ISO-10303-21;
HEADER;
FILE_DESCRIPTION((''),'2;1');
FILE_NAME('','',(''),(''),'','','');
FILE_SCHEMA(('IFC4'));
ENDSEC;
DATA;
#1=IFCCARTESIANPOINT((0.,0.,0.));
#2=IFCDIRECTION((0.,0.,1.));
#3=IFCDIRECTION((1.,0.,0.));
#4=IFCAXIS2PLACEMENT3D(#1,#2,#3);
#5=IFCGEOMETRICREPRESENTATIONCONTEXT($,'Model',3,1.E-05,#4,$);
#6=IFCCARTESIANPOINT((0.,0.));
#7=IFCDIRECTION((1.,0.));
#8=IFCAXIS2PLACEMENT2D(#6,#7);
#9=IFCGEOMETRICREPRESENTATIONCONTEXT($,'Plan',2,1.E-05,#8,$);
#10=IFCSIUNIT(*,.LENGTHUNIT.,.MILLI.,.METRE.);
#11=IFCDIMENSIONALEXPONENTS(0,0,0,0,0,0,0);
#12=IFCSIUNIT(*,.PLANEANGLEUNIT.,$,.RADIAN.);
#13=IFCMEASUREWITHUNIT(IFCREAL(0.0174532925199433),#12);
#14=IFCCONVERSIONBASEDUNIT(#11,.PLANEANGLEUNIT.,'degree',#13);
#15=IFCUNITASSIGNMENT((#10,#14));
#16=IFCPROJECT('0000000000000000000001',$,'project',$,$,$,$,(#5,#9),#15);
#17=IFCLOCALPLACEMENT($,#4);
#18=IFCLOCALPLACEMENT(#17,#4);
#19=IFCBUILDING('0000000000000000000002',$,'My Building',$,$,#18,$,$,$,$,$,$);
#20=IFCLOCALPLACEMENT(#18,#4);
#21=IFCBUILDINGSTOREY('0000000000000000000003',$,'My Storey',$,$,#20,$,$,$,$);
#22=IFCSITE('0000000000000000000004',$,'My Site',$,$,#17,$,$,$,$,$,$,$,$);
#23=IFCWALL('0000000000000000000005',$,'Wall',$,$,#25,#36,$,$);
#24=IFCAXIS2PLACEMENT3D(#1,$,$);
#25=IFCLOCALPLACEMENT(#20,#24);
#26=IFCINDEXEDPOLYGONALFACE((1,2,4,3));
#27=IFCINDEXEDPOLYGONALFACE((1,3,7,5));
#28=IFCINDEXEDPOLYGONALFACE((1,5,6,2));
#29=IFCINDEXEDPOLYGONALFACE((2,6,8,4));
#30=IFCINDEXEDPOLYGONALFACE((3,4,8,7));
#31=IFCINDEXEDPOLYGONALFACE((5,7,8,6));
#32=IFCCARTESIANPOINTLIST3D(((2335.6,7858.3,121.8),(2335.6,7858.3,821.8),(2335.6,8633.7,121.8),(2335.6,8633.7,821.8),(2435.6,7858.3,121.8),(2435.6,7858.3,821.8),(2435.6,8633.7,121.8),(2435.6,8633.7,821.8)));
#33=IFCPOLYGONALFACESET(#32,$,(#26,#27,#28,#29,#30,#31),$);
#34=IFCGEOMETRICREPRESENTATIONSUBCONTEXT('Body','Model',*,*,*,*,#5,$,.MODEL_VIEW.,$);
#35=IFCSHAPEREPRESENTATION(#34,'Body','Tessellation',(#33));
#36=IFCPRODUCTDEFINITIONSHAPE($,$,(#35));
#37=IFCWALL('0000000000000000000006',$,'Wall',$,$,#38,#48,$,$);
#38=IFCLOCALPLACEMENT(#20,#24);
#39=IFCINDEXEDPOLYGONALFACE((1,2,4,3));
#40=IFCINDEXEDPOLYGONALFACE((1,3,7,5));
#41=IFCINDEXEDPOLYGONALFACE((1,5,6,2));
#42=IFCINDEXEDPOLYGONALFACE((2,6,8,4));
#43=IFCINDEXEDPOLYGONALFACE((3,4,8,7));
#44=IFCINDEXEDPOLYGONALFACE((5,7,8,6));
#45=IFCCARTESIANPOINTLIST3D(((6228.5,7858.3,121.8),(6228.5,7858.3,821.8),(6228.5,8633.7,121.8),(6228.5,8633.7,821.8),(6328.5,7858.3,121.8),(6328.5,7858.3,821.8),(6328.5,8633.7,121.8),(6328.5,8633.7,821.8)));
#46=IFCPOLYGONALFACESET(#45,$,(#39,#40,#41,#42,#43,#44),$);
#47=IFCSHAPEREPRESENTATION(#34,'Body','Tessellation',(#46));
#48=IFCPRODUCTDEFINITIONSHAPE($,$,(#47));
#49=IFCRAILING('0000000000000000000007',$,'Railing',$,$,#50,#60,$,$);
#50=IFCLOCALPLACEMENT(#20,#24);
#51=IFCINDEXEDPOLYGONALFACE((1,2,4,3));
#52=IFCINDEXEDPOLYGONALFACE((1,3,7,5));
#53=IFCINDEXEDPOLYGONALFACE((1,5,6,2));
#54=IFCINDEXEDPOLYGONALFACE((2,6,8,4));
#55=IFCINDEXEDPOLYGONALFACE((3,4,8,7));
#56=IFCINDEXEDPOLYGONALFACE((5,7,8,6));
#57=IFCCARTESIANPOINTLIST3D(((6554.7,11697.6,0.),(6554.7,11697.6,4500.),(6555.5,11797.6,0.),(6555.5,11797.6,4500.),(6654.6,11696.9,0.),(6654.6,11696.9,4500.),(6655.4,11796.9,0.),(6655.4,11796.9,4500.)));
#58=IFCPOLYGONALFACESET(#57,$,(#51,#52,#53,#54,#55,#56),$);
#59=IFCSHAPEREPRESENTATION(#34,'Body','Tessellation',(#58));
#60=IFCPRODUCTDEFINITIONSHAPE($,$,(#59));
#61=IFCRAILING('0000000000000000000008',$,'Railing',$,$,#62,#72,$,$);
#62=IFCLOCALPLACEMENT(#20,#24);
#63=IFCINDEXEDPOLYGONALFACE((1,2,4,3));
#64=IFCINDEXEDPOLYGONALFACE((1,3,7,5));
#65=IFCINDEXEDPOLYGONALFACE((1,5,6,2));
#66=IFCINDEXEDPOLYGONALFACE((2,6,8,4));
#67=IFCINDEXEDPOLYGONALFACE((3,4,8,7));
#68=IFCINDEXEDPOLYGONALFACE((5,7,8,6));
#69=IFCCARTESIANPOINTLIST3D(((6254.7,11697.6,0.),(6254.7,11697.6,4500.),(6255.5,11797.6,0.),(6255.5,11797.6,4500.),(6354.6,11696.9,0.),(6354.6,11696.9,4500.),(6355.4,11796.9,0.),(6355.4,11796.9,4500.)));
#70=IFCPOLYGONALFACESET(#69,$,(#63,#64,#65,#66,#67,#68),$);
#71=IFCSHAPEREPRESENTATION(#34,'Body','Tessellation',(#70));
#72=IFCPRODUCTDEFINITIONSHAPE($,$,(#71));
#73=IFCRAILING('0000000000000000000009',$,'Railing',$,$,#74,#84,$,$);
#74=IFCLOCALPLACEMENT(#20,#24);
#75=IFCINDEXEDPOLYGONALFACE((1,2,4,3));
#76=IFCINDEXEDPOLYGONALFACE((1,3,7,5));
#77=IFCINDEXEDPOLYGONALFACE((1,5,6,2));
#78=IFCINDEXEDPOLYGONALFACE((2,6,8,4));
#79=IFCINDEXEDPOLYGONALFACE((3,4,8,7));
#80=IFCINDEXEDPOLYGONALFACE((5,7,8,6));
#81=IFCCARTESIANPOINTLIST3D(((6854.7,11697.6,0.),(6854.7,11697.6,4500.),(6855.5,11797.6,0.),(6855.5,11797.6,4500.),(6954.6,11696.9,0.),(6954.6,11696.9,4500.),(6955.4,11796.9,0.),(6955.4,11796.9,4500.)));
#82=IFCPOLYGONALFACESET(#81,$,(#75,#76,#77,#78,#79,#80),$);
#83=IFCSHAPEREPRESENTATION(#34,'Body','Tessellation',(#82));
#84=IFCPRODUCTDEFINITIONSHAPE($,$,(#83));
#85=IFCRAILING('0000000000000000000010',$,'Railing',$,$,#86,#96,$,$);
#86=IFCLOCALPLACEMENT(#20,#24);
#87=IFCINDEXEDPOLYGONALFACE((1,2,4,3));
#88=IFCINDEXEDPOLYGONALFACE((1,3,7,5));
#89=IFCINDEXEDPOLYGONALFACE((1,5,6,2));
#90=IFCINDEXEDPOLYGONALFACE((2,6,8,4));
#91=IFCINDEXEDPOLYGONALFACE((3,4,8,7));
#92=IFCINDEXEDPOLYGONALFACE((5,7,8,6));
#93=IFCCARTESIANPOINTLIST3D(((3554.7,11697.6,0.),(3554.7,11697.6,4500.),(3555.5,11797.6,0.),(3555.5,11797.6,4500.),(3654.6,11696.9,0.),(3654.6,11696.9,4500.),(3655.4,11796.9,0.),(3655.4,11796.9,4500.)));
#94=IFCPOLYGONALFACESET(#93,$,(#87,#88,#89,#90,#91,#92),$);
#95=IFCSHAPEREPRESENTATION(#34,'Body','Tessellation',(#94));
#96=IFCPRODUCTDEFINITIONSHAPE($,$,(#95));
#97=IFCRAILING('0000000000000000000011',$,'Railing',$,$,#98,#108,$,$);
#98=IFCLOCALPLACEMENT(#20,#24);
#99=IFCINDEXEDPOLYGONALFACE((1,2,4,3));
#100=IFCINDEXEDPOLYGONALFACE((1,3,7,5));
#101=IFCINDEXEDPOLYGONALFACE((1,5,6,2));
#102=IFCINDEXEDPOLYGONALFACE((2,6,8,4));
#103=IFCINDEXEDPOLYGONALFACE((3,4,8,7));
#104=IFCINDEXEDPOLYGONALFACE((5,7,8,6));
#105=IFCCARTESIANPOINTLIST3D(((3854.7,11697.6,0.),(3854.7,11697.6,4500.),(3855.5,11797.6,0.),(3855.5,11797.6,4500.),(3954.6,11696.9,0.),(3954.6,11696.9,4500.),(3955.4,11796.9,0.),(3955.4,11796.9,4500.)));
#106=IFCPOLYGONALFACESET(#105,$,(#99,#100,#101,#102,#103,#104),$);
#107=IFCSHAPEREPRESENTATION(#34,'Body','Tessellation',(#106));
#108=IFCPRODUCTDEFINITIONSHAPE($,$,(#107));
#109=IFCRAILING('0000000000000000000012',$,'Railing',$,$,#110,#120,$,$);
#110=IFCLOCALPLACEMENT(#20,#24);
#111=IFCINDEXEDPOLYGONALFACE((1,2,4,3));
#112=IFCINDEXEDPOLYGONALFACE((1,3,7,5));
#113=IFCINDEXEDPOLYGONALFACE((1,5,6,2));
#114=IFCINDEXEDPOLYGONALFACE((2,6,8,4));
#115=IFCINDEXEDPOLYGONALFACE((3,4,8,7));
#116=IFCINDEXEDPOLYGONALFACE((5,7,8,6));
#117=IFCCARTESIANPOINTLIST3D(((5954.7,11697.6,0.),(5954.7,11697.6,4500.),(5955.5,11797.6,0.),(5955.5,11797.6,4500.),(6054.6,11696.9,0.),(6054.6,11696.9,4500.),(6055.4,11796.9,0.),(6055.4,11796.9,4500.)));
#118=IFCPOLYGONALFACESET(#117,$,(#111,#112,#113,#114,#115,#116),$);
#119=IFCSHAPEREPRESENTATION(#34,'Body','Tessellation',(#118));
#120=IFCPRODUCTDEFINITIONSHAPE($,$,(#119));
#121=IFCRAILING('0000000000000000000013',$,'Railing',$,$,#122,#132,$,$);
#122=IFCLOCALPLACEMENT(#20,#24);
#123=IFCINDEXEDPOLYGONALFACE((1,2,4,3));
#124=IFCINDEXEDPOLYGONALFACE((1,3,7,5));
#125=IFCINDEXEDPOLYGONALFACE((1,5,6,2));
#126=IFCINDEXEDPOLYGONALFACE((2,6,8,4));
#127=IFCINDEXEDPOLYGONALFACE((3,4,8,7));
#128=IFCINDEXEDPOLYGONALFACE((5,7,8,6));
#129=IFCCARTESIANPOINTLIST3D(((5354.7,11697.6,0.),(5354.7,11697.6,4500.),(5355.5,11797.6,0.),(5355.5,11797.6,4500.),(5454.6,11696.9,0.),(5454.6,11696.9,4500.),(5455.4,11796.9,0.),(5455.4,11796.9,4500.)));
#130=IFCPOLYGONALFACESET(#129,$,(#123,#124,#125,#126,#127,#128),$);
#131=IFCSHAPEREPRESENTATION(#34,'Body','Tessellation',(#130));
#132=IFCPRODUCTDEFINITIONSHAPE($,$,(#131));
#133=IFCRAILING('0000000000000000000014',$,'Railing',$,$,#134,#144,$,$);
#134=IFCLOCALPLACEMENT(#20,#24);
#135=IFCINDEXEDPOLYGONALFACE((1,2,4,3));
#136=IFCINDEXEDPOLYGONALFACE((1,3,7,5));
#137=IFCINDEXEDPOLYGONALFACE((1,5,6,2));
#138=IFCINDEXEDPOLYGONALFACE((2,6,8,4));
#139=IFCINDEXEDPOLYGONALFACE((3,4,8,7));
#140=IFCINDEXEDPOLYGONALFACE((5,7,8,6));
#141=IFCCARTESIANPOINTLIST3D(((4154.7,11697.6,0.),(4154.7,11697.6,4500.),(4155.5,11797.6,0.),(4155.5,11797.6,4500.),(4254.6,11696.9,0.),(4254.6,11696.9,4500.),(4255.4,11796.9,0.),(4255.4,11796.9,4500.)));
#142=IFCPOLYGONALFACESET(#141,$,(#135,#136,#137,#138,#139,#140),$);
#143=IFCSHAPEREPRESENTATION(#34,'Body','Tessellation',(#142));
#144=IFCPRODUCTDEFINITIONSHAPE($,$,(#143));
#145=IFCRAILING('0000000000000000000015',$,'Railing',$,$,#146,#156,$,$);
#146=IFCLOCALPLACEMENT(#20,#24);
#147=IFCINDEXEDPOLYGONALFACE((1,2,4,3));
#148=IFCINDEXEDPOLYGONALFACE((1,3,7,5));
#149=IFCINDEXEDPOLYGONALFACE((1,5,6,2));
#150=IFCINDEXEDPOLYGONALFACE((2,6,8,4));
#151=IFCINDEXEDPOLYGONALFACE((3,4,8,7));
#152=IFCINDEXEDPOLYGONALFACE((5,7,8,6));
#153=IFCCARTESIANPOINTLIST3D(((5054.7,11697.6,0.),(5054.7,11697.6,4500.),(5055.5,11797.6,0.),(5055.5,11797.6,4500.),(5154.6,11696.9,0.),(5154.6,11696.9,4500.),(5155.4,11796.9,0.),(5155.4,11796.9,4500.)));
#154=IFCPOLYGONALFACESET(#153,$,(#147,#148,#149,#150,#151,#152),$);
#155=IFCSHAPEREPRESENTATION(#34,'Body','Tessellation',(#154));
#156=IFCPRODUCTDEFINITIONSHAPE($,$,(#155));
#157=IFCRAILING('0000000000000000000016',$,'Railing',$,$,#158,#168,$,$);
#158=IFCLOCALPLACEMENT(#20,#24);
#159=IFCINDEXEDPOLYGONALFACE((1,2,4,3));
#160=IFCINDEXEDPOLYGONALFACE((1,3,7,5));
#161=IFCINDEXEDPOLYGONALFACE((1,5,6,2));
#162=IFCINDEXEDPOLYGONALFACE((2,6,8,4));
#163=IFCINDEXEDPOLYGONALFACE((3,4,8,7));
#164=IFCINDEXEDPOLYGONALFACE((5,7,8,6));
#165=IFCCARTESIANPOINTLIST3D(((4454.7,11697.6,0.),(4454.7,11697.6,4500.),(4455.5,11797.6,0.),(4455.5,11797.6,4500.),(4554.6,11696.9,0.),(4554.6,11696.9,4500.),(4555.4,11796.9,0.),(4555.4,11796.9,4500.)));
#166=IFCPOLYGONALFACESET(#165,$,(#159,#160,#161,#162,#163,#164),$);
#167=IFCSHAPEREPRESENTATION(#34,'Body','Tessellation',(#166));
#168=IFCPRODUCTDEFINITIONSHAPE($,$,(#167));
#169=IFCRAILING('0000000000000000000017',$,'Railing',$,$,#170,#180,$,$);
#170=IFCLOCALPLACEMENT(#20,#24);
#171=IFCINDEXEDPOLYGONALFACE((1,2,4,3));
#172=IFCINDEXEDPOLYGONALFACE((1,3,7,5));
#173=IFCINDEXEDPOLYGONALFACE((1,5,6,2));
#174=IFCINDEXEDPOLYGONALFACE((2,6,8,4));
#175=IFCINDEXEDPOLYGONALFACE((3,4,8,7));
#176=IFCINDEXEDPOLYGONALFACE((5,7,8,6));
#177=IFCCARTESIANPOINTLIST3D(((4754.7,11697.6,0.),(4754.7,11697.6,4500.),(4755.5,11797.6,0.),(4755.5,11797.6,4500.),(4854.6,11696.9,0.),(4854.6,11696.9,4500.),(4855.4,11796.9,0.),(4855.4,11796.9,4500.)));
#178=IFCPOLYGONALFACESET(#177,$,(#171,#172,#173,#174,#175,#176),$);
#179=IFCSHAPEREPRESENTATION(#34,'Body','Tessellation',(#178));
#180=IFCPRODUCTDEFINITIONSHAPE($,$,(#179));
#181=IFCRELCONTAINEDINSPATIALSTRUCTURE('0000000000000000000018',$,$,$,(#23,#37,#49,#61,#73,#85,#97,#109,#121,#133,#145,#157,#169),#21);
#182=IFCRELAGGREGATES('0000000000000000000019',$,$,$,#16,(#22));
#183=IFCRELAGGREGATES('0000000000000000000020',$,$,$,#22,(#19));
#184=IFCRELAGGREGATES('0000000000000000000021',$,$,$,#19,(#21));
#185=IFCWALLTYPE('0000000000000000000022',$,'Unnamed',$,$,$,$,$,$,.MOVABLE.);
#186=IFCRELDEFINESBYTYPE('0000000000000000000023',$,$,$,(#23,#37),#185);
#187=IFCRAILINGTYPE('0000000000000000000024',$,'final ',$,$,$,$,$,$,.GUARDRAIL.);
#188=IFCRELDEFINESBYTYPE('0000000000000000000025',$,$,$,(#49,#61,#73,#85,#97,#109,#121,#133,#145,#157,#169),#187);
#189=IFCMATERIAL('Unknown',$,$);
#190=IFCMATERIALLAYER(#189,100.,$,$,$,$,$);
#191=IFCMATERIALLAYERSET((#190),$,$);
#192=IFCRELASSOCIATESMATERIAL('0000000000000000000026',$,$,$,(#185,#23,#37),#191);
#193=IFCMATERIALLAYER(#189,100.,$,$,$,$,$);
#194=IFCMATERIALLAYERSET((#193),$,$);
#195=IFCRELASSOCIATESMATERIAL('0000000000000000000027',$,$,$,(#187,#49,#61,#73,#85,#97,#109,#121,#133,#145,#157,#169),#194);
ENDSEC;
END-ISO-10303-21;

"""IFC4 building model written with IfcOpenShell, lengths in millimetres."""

from ifc_helpers import new_model, entity, si_unit, converted_unit, frame, origin_with_axes, origin_2d_with_axis, place, context, subcontext, project, spatial, line, indexed_curve, outline, extrude, material, layer, layer_set, layer_usage, type_object, element, save


model = new_model("IFC4")

# Units and contexts
model_context = context("Model", 3, precision=1e-05, world=origin_with_axes())
plan_context = context("Plan", 2, precision=1e-05, world=origin_2d_with_axis())
body_context = subcontext(model_context, "Body", "Model", "MODEL_VIEW")
ifc_project = project(units=[si_unit("LENGTHUNIT", "METRE", prefix="MILLI"), converted_unit("PLANEANGLEUNIT", "degree", entity("IfcReal", 0.0174532925199433), si_unit("PLANEANGLEUNIT", "RADIAN"), dimensions=[0, 0, 0, 0, 0, 0, 0])], contexts=[model_context, plan_context])

# Site, building, storey
site_placement = place(None, origin_with_axes())
site = spatial("IfcSite", under=ifc_project, at=site_placement, Name="My Site")
building_placement = place(site_placement, origin_with_axes())
building = spatial("IfcBuilding", under=site, at=building_placement, Name="My Building")
storey_placement = place(building_placement, origin_with_axes())
storey = spatial("IfcBuildingStorey", under=building, at=storey_placement, Name="My Storey")

# Shared definitions
ifc_material = material(Name="Unknown")

# Walls
ifc_layer_1 = layer(ifc_material, 100.0)
ifc_layer_set_1 = layer_set([ifc_layer_1])
ifc_layer_usage_1 = layer_usage(ifc_layer_set_1, "AXIS2", "POSITIVE", 0.0)
wall_type = type_object("IfcWallType", Name="Unnamed", PredefinedType="MOVABLE", material=ifc_layer_set_1)
wall_1_placement = place(storey_placement, frame((2335.6, 8633.7, 121.8), z_axis=(0.0, 0.0, 1.0), x_axis=(0.0, -1.0, 0.0)))
element("IfcWall", 1, at=wall_1_placement, inside=storey, type_object=wall_type, material=ifc_layer_usage_1, Name="Wall", context=body_context, shape_type="SweptSolid", body=[
    extrude(outline(indexed_curve([(0.0, 0.0), (0.0, 100.0), (775.4, 100.0), (775.4, 0.0)], segments=[line(1, 2, 3, 4, 1)])), origin_with_axes(), (0.0, 0.0, 1.0), 700.0),
])
ifc_layer_usage_2 = layer_usage(ifc_layer_set_1, "AXIS2", "POSITIVE", 0.0)
wall_2_placement = place(storey_placement, frame((6228.5, 8633.7, 121.8), z_axis=(0.0, 0.0, 1.0), x_axis=(0.0, -1.0, 0.0)))
element("IfcWall", 2, at=wall_2_placement, inside=storey, type_object=wall_type, material=ifc_layer_usage_2, Name="Wall", context=body_context, shape_type="SweptSolid", body=[
    extrude(outline(indexed_curve([(0.0, 0.0), (0.0, 100.0), (775.4, 100.0), (775.4, 0.0)], segments=[line(1, 2, 3, 4, 1)])), origin_with_axes(), (0.0, 0.0, 1.0), 700.0),
])

# Railings
ifc_layer_2 = layer(ifc_material, 100.0)
ifc_layer_set_2 = layer_set([ifc_layer_2])
ifc_layer_usage_3 = layer_usage(ifc_layer_set_2, "AXIS2", "POSITIVE", 0.0)
railing_type = type_object("IfcRailingType", Name="final ", PredefinedType="GUARDRAIL", material=ifc_layer_set_2)
railing_1_placement = place(storey_placement, frame((6655.4, 11796.9, 0.0), z_axis=(0.0, 0.0, 1.0), x_axis=(-0.99997, 0.007689, 0.0)))
element("IfcRailing", 3, at=railing_1_placement, inside=storey, type_object=railing_type, material=ifc_layer_usage_3, Name="Railing", context=body_context, shape_type="SweptSolid", body=[
    extrude(outline(indexed_curve([(0.0, 0.0), (0.0, 100.0), (99.8, 100.0), (99.8, 0.0)], segments=[line(1, 2, 3, 4, 1)])), origin_with_axes(), (0.0, 0.0, 1.0), 4500.0),
])
ifc_layer_usage_4 = layer_usage(ifc_layer_set_2, "AXIS2", "POSITIVE", 0.0)
railing_2_placement = place(storey_placement, frame((6355.4, 11796.9, 0.0), z_axis=(0.0, 0.0, 1.0), x_axis=(-0.99997, 0.007689, 0.0)))
element("IfcRailing", 4, at=railing_2_placement, inside=storey, type_object=railing_type, material=ifc_layer_usage_4, Name="Railing", context=body_context, shape_type="SweptSolid", body=[
    extrude(outline(indexed_curve([(0.0, 0.0), (0.0, 100.0), (99.8, 100.0), (99.8, 0.0)], segments=[line(1, 2, 3, 4, 1)])), origin_with_axes(), (0.0, 0.0, 1.0), 4500.0),
])
ifc_layer_usage_5 = layer_usage(ifc_layer_set_2, "AXIS2", "POSITIVE", 0.0)
railing_3_placement = place(storey_placement, frame((6955.4, 11796.9, 0.0), z_axis=(0.0, 0.0, 1.0), x_axis=(-0.99997, 0.007689, 0.0)))
element("IfcRailing", 5, at=railing_3_placement, inside=storey, type_object=railing_type, material=ifc_layer_usage_5, Name="Railing", context=body_context, shape_type="SweptSolid", body=[
    extrude(outline(indexed_curve([(0.0, 0.0), (0.0, 100.0), (99.8, 100.0), (99.8, 0.0)], segments=[line(1, 2, 3, 4, 1)])), origin_with_axes(), (0.0, 0.0, 1.0), 4500.0),
])
ifc_layer_usage_6 = layer_usage(ifc_layer_set_2, "AXIS2", "POSITIVE", 0.0)
railing_4_placement = place(storey_placement, frame((3655.4, 11796.9, 0.0), z_axis=(0.0, 0.0, 1.0), x_axis=(-0.99997, 0.007689, 0.0)))
element("IfcRailing", 6, at=railing_4_placement, inside=storey, type_object=railing_type, material=ifc_layer_usage_6, Name="Railing", context=body_context, shape_type="SweptSolid", body=[
    extrude(outline(indexed_curve([(0.0, 0.0), (0.0, 100.0), (99.8, 100.0), (99.8, 0.0)], segments=[line(1, 2, 3, 4, 1)])), origin_with_axes(), (0.0, 0.0, 1.0), 4500.0),
])
ifc_layer_usage_7 = layer_usage(ifc_layer_set_2, "AXIS2", "POSITIVE", 0.0)
railing_5_placement = place(storey_placement, frame((3955.4, 11796.9, 0.0), z_axis=(0.0, 0.0, 1.0), x_axis=(-0.99997, 0.007689, 0.0)))
element("IfcRailing", 7, at=railing_5_placement, inside=storey, type_object=railing_type, material=ifc_layer_usage_7, Name="Railing", context=body_context, shape_type="SweptSolid", body=[
    extrude(outline(indexed_curve([(0.0, 0.0), (0.0, 100.0), (99.8, 100.0), (99.8, 0.0)], segments=[line(1, 2, 3, 4, 1)])), origin_with_axes(), (0.0, 0.0, 1.0), 4500.0),
])
ifc_layer_usage_8 = layer_usage(ifc_layer_set_2, "AXIS2", "POSITIVE", 0.0)
railing_6_placement = place(storey_placement, frame((6055.4, 11796.9, 0.0), z_axis=(0.0, 0.0, 1.0), x_axis=(-0.99997, 0.007689, 0.0)))
element("IfcRailing", 8, at=railing_6_placement, inside=storey, type_object=railing_type, material=ifc_layer_usage_8, Name="Railing", context=body_context, shape_type="SweptSolid", body=[
    extrude(outline(indexed_curve([(0.0, 0.0), (0.0, 100.0), (99.8, 100.0), (99.8, 0.0)], segments=[line(1, 2, 3, 4, 1)])), origin_with_axes(), (0.0, 0.0, 1.0), 4500.0),
])
ifc_layer_usage_9 = layer_usage(ifc_layer_set_2, "AXIS2", "POSITIVE", 0.0)
railing_7_placement = place(storey_placement, frame((5455.4, 11796.9, 0.0), z_axis=(0.0, 0.0, 1.0), x_axis=(-0.99997, 0.007689, 0.0)))
element("IfcRailing", 9, at=railing_7_placement, inside=storey, type_object=railing_type, material=ifc_layer_usage_9, Name="Railing", context=body_context, shape_type="SweptSolid", body=[
    extrude(outline(indexed_curve([(0.0, 0.0), (0.0, 100.0), (99.8, 100.0), (99.8, 0.0)], segments=[line(1, 2, 3, 4, 1)])), origin_with_axes(), (0.0, 0.0, 1.0), 4500.0),
])
ifc_layer_usage_10 = layer_usage(ifc_layer_set_2, "AXIS2", "POSITIVE", 0.0)
railing_8_placement = place(storey_placement, frame((4255.4, 11796.9, 0.0), z_axis=(0.0, 0.0, 1.0), x_axis=(-0.99997, 0.007689, 0.0)))
element("IfcRailing", 10, at=railing_8_placement, inside=storey, type_object=railing_type, material=ifc_layer_usage_10, Name="Railing", context=body_context, shape_type="SweptSolid", body=[
    extrude(outline(indexed_curve([(0.0, 0.0), (0.0, 100.0), (99.8, 100.0), (99.8, 0.0)], segments=[line(1, 2, 3, 4, 1)])), origin_with_axes(), (0.0, 0.0, 1.0), 4500.0),
])
ifc_layer_usage_11 = layer_usage(ifc_layer_set_2, "AXIS2", "POSITIVE", 0.0)
railing_9_placement = place(storey_placement, frame((5155.4, 11796.9, 0.0), z_axis=(0.0, 0.0, 1.0), x_axis=(-0.99997, 0.007689, 0.0)))
element("IfcRailing", 11, at=railing_9_placement, inside=storey, type_object=railing_type, material=ifc_layer_usage_11, Name="Railing", context=body_context, shape_type="SweptSolid", body=[
    extrude(outline(indexed_curve([(0.0, 0.0), (0.0, 100.0), (99.8, 100.0), (99.8, 0.0)], segments=[line(1, 2, 3, 4, 1)])), origin_with_axes(), (0.0, 0.0, 1.0), 4500.0),
])
ifc_layer_usage_12 = layer_usage(ifc_layer_set_2, "AXIS2", "POSITIVE", 0.0)
railing_10_placement = place(storey_placement, frame((4555.4, 11796.9, 0.0), z_axis=(0.0, 0.0, 1.0), x_axis=(-0.99997, 0.007689, 0.0)))
element("IfcRailing", 12, at=railing_10_placement, inside=storey, type_object=railing_type, material=ifc_layer_usage_12, Name="Railing", context=body_context, shape_type="SweptSolid", body=[
    extrude(outline(indexed_curve([(0.0, 0.0), (0.0, 100.0), (99.8, 100.0), (99.8, 0.0)], segments=[line(1, 2, 3, 4, 1)])), origin_with_axes(), (0.0, 0.0, 1.0), 4500.0),
])
ifc_layer_usage_13 = layer_usage(ifc_layer_set_2, "AXIS2", "POSITIVE", 0.0)
railing_11_placement = place(storey_placement, frame((4855.4, 11796.9, 0.0), z_axis=(0.0, 0.0, 1.0), x_axis=(-0.99997, 0.007689, 0.0)))
element("IfcRailing", 13, at=railing_11_placement, inside=storey, type_object=railing_type, material=ifc_layer_usage_13, Name="Railing", context=body_context, shape_type="SweptSolid", body=[
    extrude(outline(indexed_curve([(0.0, 0.0), (0.0, 100.0), (99.8, 100.0), (99.8, 0.0)], segments=[line(1, 2, 3, 4, 1)])), origin_with_axes(), (0.0, 0.0, 1.0), 4500.0),
])

save(model, "model.ifc")
